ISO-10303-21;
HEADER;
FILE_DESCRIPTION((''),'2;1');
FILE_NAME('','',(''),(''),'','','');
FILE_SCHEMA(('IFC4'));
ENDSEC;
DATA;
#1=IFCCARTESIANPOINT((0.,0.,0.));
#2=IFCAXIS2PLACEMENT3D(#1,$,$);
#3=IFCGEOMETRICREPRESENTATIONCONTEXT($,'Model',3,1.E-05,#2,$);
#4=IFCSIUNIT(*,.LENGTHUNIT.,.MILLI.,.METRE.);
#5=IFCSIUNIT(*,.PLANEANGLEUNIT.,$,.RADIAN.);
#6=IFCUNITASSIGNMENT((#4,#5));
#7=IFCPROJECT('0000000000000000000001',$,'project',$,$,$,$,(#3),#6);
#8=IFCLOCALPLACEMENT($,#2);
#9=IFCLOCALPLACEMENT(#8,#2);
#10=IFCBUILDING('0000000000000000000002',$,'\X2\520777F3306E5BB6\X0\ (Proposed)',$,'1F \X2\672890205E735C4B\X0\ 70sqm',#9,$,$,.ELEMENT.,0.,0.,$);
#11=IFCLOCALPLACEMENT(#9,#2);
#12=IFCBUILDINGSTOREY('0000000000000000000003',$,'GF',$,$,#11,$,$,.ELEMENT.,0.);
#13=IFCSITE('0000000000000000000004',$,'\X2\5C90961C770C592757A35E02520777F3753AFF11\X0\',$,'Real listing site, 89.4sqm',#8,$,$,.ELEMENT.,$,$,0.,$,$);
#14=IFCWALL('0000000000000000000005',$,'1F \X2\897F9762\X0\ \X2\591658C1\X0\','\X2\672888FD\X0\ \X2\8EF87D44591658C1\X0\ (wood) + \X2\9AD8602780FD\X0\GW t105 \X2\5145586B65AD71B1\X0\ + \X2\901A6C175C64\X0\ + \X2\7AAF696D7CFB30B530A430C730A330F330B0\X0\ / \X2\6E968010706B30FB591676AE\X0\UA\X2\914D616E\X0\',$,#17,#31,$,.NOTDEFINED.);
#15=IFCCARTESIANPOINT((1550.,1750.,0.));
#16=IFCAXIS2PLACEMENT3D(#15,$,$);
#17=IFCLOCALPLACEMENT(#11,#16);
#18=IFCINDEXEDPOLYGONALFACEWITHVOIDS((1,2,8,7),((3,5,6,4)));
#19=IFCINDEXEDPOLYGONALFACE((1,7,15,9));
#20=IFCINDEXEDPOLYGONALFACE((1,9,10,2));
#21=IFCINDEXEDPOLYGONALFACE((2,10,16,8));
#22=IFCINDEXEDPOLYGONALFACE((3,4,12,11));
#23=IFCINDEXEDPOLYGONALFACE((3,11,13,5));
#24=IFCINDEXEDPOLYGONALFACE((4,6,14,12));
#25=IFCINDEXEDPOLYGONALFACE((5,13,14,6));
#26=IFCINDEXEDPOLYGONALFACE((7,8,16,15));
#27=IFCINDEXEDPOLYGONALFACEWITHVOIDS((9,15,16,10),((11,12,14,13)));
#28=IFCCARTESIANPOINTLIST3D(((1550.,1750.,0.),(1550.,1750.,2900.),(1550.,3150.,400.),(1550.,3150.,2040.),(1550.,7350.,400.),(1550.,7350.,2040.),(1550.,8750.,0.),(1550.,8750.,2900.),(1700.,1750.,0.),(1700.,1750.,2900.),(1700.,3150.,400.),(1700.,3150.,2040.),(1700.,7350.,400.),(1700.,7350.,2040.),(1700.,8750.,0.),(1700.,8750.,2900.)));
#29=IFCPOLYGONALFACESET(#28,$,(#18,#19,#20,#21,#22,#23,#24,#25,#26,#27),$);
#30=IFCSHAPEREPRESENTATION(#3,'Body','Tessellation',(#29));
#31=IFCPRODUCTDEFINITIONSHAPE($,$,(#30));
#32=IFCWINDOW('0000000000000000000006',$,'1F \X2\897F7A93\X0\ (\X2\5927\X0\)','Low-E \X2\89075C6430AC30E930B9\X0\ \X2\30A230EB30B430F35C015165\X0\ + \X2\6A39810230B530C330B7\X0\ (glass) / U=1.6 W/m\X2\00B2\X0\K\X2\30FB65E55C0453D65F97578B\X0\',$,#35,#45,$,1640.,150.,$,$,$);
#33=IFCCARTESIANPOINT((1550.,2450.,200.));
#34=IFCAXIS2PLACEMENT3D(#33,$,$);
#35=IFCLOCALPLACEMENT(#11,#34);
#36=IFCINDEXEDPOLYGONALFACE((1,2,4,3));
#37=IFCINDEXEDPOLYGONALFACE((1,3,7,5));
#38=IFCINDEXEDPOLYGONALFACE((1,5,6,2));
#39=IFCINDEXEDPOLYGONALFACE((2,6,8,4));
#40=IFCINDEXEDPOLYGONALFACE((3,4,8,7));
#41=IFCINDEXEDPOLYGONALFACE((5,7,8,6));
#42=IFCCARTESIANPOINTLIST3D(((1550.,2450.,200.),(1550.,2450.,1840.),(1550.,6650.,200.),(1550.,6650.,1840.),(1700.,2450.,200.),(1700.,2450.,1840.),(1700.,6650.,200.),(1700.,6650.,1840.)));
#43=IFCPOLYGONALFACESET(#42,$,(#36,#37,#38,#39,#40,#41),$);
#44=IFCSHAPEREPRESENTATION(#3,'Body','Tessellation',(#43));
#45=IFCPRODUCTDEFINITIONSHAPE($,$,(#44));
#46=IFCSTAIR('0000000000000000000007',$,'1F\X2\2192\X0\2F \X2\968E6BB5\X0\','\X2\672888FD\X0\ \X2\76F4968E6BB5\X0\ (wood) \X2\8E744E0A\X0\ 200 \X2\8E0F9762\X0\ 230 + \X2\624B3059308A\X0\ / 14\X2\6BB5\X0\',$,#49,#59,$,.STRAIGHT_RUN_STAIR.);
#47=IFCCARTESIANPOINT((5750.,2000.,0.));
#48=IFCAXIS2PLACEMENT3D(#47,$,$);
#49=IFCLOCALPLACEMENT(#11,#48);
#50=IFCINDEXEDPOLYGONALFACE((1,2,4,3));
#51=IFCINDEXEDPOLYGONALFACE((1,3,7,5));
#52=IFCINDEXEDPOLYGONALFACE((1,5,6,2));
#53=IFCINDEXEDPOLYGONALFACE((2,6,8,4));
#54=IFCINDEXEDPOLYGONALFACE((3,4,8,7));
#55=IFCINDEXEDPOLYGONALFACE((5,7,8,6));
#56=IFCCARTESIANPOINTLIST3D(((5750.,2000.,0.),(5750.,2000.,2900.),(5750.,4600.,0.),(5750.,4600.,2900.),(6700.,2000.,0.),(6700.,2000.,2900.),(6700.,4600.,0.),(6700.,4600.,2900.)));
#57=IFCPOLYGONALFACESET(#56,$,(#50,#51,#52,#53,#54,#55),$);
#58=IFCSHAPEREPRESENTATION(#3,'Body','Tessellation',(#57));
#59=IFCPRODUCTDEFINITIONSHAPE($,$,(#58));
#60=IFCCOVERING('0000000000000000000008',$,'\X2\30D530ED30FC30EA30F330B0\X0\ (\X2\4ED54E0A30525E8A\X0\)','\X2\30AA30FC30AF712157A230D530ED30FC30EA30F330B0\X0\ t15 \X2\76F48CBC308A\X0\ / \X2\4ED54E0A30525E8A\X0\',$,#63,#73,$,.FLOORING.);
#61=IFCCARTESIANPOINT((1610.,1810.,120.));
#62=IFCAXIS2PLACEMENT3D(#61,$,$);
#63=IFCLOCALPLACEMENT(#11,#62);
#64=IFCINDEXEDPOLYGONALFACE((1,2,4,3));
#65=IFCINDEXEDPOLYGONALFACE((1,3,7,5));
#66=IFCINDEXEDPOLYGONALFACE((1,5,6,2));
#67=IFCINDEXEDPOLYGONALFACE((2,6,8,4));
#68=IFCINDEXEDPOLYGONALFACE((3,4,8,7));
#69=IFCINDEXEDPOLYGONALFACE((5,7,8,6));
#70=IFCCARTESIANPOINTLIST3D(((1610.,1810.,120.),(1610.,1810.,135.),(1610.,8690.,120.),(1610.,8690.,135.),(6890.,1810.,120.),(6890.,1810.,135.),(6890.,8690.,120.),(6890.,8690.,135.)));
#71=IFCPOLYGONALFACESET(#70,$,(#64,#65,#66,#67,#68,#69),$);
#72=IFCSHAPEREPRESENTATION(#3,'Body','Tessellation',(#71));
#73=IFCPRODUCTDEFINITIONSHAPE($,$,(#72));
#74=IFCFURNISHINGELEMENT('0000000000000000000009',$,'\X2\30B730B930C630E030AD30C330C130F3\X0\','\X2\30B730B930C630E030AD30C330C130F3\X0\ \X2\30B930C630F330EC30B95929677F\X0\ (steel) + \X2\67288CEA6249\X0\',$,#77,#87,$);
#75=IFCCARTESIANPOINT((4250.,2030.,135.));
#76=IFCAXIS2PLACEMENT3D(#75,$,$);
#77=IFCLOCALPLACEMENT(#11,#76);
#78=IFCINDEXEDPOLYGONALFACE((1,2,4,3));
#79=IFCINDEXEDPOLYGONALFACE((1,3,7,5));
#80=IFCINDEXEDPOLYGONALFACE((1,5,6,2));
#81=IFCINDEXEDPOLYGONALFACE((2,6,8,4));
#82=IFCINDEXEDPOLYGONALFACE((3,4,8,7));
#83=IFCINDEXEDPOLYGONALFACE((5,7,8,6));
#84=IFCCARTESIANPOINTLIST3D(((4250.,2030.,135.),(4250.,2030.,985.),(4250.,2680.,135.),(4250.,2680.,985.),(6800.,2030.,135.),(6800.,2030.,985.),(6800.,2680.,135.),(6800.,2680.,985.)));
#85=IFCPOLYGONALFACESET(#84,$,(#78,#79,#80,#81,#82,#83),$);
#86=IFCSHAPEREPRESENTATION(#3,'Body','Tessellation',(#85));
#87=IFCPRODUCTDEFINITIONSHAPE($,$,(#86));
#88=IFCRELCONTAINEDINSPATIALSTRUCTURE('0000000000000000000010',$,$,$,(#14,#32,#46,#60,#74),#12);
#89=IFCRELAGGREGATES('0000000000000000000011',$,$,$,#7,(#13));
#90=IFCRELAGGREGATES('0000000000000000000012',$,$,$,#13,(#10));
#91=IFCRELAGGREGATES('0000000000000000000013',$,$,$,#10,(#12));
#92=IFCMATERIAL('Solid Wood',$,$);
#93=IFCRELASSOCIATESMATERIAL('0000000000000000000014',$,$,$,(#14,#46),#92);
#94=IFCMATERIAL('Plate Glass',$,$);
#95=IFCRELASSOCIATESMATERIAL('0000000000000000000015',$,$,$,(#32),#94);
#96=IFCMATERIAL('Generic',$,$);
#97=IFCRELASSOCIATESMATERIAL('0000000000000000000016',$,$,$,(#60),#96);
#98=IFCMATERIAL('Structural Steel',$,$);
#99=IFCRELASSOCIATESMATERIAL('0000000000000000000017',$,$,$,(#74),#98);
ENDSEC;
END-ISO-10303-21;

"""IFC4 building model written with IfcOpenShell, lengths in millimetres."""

from ifc_helpers import new_model, si_unit, frame, frame_2d, origin, place, context, project, spatial, rectangle, extrude, material, element, fill, save


model = new_model("IFC4")

# Units and contexts
model_context = context("Model", 3, precision=1e-05, world=origin())
ifc_project = project(units=[si_unit("LENGTHUNIT", "METRE", prefix="MILLI"), si_unit("PLANEANGLEUNIT", "RADIAN")], contexts=[model_context])

# Site, building, storey
site_placement = place(None, origin())
site = spatial("IfcSite", under=ifc_project, at=site_placement, Name="岐阜県大垣市切石町１", ObjectType="Real listing site, 89.4sqm", CompositionType="ELEMENT", RefElevation=0.0)
building_placement = place(site_placement, origin())
building = spatial("IfcBuilding", under=site, at=building_placement, Name="切石の家 (Proposed)", ObjectType="1F 木造平屋 70sqm", CompositionType="ELEMENT", ElevationOfRefHeight=0.0, ElevationOfTerrain=0.0)
storey_placement = place(building_placement, origin())
storey = spatial("IfcBuildingStorey", under=building, at=storey_placement, Name="GF", CompositionType="ELEMENT", Elevation=0.0)

# Shared definitions
ifc_material_1 = material(Name="Solid Wood")
ifc_material_2 = material(Name="Generic")

# Shared definitions
ifc_material_3 = material(Name="Plate Glass")

# Wall, opening, window
wall_1_placement = place(storey_placement, frame((1550.0, 1750.0, 0.0)))
wall_1 = element("IfcWall", 1, at=wall_1_placement, inside=storey, material=ifc_material_1, Name="1F 西面 外壁", Description="木製 軸組外壁 (wood) + 高性能GW t105 充填断熱 + 通気層 + 窯業系サイディング / 準耐火・外皮UA配慮", PredefinedType="NOTDEFINED", context=model_context, shape_type="SweptSolid", body=[
    extrude(rectangle(XDim=150.0, YDim=7000.0, at=frame_2d((75.0, 3500.0))), frame((1550.0, 1750.0, 0.0)), (0.0, 0.0, 1.0), 2900.0),
])
opening_1_placement = place(storey_placement, frame((1550.0, 2450.0, 200.0)))
opening_1 = element("IfcOpeningElement", 2, at=opening_1_placement, cuts=wall_1, PredefinedType="NOTDEFINED", context=model_context, shape_type="SweptSolid", body=[
    extrude(rectangle(XDim=150.0, YDim=4200.0, at=frame_2d((75.0, 2100.0))), frame((1550.0, 2450.0, 200.0)), (0.0, 0.0, 1.0), 1640.0),
])
window_1_placement = place(storey_placement, frame((1550.0, 2450.0, 200.0)))
window_1 = element("IfcWindow", 3, at=window_1_placement, inside=storey, material=ifc_material_3, Name="1F 西窓 (大)", Description="Low-E 複層ガラス アルゴン封入 + 樹脂サッシ (glass) / U=1.6 W/m²K・日射取得型", OverallHeight=1640.0, OverallWidth=150.0, context=model_context, shape_type="SweptSolid", body=[
    extrude(rectangle(XDim=150.0, YDim=4200.0, at=frame_2d((75.0, 2100.0))), frame((1550.0, 2450.0, 200.0)), (0.0, 0.0, 1.0), 1640.0),
])
fill(opening_1, window_1)

# Stair
stair_placement = place(storey_placement, frame((5750.0, 2000.0, 0.0)))
element("IfcStair", 4, at=stair_placement, inside=storey, material=ifc_material_1, Name="1F→2F 階段", Description="木製 直階段 (wood) 蹴上 200 踏面 230 + 手すり / 14段", PredefinedType="STRAIGHT_RUN_STAIR", context=model_context, shape_type="SweptSolid", body=[
    extrude(rectangle(XDim=950.0, YDim=2600.0, at=frame_2d((475.0, 1300.0))), frame((5750.0, 2000.0, 0.0)), (0.0, 0.0, 1.0), 2900.0),
])

# Covering
covering_placement = place(storey_placement, frame((1610.0, 1810.0, 120.0)))
element("IfcCovering", 5, at=covering_placement, inside=storey, material=ifc_material_2, Name="フローリング (仕上げ床)", Description="オーク無垢フローリング t15 直貼り / 仕上げ床", PredefinedType="FLOORING", context=model_context, shape_type="SweptSolid", body=[
    extrude(rectangle(XDim=5280.0, YDim=6880.0, at=frame_2d((2640.0, 3440.0))), frame((1610.0, 1810.0, 120.0)), (0.0, 0.0, 1.0), 15.0),
])

# Furnishing element
ifc_material_4 = material(Name="Structural Steel")
furnishing_placement = place(storey_placement, frame((4250.0, 2030.0, 135.0)))
element("IfcFurnishingElement", 6, at=furnishing_placement, inside=storey, material=ifc_material_4, Name="システムキッチン", Description="システムキッチン ステンレス天板 (steel) + 木質扉", context=model_context, shape_type="SweptSolid", body=[
    extrude(rectangle(XDim=2550.0, YDim=650.0, at=frame_2d((1275.0, 325.0))), frame((4250.0, 2030.0, 135.0)), (0.0, 0.0, 1.0), 850.0),
])

save(model, "model.ifc")
